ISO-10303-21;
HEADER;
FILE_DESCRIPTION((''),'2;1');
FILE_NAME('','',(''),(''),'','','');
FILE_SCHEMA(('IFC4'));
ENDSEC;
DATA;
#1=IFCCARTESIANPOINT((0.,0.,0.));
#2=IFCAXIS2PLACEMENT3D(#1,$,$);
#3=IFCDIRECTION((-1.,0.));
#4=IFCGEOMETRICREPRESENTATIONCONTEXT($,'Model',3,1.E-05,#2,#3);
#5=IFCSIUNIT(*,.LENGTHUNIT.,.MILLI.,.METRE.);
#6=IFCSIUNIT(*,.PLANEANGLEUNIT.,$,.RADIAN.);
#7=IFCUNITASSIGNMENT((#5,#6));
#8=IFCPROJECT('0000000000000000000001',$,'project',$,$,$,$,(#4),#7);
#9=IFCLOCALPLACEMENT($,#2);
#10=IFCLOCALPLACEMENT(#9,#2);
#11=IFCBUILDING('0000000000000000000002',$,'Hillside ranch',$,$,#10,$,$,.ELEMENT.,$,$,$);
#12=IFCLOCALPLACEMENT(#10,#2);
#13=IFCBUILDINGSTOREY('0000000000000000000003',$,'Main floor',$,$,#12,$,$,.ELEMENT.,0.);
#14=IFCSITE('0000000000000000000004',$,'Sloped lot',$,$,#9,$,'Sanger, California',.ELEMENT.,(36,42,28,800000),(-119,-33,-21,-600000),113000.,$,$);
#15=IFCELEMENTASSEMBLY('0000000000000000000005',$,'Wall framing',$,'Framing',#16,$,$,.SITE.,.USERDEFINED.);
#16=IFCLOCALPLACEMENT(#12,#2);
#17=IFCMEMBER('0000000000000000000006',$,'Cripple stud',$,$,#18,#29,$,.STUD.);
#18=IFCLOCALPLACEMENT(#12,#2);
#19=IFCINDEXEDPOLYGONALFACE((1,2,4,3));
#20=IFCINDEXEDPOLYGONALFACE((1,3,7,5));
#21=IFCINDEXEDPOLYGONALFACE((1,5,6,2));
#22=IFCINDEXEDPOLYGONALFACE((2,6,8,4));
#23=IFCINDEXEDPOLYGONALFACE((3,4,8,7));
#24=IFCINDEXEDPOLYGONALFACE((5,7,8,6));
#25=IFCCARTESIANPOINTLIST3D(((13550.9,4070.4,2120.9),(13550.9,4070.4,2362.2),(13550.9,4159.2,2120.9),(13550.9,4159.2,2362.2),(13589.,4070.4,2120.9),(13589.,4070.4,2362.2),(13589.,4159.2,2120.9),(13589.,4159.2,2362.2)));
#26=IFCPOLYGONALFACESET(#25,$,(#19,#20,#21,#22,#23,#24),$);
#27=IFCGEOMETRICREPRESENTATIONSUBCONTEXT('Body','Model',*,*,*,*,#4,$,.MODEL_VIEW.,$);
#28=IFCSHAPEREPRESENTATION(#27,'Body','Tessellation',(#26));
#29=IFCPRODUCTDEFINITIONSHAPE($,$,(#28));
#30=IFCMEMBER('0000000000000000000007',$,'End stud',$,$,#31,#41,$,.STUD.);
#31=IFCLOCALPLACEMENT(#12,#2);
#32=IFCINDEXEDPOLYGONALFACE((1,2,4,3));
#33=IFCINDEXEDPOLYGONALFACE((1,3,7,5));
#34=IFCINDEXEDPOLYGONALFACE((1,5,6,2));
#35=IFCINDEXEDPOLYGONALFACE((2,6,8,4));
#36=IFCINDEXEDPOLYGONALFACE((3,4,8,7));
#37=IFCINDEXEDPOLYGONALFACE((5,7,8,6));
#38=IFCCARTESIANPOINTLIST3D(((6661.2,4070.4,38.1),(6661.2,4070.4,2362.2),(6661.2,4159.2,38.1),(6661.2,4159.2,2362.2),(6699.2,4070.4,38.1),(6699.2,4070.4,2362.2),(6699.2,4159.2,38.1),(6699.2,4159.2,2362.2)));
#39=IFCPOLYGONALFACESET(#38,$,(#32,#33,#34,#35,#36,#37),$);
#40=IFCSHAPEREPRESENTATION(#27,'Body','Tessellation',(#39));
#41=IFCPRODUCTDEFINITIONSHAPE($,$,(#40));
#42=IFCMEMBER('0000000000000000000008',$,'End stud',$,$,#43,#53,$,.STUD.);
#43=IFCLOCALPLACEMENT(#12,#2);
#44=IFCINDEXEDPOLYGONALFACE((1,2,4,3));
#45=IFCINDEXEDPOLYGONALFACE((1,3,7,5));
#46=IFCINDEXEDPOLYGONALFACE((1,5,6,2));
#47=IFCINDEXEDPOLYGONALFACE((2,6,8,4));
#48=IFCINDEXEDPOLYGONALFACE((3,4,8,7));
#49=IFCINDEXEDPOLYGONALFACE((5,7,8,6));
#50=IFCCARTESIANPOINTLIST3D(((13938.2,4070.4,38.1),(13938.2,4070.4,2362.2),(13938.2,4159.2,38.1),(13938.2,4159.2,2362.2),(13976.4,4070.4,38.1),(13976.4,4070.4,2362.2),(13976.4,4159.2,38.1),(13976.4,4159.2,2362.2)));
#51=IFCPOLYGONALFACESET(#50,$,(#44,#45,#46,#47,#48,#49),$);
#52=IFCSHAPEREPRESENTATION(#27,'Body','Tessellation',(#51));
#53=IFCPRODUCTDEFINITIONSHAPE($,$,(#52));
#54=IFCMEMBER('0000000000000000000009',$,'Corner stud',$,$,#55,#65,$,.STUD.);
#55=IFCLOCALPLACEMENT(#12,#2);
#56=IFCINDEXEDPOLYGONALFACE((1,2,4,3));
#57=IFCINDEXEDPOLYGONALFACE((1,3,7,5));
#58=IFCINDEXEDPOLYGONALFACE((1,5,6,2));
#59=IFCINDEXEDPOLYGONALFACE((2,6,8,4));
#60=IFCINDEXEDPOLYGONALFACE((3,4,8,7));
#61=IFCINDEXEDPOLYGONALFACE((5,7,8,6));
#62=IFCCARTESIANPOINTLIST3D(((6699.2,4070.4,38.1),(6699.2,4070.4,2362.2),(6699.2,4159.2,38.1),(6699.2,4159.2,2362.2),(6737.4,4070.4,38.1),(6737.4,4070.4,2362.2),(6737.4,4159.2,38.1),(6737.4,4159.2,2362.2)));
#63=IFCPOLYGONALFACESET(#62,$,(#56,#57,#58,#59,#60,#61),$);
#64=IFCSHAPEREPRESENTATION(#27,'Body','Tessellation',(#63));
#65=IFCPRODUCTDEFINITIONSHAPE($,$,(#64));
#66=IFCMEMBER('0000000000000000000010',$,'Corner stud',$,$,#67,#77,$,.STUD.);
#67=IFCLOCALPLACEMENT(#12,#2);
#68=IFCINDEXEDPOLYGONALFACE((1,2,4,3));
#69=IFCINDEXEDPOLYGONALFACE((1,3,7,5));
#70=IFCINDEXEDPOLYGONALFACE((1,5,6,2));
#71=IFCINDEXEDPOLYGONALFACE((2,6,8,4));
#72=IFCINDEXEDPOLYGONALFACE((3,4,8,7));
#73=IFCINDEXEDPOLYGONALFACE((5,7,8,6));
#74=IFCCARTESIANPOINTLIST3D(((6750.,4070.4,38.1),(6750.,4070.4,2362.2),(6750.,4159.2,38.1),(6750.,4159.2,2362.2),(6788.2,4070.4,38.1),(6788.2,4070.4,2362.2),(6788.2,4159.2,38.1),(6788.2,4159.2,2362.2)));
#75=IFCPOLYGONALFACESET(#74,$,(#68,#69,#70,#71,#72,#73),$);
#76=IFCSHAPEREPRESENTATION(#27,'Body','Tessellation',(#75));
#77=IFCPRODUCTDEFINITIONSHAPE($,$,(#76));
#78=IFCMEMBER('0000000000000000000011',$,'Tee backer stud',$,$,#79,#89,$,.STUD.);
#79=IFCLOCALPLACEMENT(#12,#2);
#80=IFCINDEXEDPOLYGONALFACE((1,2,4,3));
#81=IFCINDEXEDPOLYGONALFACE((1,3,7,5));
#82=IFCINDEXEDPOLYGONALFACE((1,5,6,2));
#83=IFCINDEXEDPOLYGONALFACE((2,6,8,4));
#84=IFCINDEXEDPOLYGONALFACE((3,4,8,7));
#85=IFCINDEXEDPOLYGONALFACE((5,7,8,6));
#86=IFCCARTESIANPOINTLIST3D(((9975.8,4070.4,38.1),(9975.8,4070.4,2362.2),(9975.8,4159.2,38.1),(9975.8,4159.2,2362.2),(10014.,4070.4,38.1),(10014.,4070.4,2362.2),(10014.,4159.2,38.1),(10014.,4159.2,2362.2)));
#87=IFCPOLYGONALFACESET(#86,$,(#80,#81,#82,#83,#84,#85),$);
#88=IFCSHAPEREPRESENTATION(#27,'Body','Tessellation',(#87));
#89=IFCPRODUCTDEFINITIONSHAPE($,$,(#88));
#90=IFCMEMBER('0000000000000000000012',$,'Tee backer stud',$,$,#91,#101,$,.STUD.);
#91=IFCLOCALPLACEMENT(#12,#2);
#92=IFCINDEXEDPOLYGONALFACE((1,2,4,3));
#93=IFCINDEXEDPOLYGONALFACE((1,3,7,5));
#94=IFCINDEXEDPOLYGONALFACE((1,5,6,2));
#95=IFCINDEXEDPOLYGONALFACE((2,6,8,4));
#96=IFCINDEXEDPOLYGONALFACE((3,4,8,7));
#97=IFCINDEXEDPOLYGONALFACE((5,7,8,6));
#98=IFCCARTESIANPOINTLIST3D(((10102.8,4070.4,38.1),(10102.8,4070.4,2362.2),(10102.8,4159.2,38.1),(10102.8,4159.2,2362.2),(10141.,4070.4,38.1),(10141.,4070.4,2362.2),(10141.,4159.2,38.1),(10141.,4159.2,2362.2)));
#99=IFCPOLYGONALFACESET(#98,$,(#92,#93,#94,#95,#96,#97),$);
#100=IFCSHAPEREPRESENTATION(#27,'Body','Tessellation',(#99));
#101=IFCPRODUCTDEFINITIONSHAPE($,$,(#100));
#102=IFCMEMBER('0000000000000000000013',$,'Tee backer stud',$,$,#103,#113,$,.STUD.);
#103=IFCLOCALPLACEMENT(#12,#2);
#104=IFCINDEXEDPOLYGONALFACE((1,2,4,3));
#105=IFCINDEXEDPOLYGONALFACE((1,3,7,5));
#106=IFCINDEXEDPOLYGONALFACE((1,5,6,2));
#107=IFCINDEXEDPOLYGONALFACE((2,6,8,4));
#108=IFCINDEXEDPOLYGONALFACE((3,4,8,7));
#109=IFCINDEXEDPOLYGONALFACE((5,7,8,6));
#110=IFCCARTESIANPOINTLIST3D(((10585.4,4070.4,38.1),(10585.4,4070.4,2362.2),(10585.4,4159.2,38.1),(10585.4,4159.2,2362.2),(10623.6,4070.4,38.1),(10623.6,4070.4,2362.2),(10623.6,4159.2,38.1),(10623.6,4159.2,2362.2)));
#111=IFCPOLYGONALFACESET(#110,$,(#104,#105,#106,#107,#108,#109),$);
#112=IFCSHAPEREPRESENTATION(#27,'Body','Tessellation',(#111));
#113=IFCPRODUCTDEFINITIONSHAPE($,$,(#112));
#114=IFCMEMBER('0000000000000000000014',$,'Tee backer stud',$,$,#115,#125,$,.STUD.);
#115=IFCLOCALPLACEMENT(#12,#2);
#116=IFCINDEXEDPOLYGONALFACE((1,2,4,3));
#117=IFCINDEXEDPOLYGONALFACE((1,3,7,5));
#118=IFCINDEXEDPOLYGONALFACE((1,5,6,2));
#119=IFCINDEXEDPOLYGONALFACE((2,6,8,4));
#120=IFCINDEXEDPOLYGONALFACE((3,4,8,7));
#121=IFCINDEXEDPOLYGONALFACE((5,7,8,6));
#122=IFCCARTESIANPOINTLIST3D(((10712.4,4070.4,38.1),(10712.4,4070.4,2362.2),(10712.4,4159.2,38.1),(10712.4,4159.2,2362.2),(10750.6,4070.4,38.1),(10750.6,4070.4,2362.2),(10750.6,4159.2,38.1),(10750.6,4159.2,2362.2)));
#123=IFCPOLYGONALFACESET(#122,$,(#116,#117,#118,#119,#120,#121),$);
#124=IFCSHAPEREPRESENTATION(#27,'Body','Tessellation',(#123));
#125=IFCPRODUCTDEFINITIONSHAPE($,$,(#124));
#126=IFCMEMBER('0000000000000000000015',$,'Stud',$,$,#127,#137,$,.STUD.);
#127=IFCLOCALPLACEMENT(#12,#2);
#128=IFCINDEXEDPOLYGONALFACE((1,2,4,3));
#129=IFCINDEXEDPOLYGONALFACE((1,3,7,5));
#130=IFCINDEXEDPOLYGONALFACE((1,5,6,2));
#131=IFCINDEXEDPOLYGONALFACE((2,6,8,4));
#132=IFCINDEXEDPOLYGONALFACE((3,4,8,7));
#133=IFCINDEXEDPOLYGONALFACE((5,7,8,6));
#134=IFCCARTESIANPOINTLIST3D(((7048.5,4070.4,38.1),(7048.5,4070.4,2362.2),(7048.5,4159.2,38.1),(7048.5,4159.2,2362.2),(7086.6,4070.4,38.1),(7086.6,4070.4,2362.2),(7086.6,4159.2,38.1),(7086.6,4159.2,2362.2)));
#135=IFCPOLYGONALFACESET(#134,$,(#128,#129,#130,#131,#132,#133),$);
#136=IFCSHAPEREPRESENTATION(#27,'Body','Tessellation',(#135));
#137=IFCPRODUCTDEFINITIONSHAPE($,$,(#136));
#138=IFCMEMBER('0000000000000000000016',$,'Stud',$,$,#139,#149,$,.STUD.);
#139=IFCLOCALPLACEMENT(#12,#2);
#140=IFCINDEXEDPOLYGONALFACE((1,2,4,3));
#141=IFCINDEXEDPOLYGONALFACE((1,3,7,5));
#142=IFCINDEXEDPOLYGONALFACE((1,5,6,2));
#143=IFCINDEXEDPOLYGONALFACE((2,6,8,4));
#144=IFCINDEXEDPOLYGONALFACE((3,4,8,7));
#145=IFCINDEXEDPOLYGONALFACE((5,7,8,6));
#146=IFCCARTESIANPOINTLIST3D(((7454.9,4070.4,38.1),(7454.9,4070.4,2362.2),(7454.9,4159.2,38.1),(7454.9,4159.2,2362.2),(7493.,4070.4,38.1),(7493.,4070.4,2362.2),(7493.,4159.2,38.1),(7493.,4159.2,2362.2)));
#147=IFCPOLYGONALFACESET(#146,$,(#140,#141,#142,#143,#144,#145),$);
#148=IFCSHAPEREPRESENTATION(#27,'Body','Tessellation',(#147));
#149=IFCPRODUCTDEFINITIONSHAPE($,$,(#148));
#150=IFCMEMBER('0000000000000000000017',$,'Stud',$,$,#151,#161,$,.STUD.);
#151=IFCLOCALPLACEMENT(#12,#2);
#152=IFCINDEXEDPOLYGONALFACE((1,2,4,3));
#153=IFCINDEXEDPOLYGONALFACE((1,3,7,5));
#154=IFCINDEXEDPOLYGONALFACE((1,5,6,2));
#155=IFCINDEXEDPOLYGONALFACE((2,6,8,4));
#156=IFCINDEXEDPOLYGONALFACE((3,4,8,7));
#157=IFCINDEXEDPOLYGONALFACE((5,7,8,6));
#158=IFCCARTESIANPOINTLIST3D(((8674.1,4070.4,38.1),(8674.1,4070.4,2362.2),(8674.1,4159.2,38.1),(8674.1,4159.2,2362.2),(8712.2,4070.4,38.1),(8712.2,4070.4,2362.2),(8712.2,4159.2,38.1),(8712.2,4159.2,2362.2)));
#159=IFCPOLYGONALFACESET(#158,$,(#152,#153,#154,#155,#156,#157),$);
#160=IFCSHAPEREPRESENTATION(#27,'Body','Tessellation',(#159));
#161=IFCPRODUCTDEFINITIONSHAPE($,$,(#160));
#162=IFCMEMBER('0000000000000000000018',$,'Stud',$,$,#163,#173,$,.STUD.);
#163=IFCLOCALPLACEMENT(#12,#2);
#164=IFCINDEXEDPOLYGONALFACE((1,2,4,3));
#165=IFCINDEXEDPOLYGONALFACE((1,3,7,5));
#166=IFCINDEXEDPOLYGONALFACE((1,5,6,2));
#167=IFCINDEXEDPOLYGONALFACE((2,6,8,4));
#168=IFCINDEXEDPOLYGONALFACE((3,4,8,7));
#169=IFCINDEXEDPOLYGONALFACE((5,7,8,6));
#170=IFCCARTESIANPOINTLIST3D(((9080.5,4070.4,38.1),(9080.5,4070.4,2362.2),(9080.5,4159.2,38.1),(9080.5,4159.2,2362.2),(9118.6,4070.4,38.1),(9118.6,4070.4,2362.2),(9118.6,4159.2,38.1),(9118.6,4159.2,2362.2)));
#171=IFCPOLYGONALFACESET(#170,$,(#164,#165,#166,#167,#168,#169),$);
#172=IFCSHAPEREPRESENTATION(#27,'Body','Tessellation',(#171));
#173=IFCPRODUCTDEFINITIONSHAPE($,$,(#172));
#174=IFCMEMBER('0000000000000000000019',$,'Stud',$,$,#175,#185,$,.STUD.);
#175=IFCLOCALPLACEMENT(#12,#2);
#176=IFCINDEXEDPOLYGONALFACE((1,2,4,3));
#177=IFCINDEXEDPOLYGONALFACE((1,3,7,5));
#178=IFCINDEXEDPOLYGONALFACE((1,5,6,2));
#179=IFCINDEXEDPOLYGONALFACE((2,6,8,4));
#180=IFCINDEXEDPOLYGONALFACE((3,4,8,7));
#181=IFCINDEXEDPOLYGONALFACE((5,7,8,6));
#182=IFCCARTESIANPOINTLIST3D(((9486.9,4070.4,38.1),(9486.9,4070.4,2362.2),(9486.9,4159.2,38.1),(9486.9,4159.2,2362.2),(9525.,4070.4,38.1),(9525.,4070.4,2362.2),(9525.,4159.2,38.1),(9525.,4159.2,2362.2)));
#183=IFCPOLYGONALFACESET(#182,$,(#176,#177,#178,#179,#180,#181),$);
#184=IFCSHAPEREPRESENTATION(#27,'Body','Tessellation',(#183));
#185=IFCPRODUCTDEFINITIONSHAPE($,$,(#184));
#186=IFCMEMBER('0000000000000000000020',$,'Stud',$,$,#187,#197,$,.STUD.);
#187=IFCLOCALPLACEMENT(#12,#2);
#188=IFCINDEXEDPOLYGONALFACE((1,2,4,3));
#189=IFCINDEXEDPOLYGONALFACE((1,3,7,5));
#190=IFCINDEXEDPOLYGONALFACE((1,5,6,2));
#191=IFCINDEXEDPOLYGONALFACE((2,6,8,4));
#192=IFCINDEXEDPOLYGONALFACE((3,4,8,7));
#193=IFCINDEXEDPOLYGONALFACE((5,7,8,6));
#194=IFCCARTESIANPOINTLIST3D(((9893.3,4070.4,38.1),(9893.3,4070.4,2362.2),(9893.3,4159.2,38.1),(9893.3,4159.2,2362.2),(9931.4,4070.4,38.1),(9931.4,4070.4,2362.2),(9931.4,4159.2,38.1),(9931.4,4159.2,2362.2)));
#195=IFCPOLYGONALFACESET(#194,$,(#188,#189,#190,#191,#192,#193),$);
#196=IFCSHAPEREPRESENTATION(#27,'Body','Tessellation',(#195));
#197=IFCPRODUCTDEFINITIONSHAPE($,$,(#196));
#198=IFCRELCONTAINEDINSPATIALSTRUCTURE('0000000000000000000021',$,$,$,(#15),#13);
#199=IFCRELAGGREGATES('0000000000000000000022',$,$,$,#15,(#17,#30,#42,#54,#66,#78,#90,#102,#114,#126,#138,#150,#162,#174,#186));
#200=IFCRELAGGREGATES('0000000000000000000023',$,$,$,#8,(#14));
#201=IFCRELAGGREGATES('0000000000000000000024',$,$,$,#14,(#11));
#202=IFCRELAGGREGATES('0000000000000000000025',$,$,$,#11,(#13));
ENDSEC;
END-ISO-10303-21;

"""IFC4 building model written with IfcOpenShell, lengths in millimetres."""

from ifc_helpers import new_model, si_unit, direction, frame, origin, origin_with_axes, place, context, subcontext, project, spatial, polyline, outline, extrude, element, aggregate, save


model = new_model("IFC4")

# Units and contexts
model_context = context("Model", 3, precision=1e-05, world=origin(), true_north=direction((-1.0, 0.0)))
body_context = subcontext(model_context, "Body", "Model", "MODEL_VIEW")
ifc_project = project(units=[si_unit("LENGTHUNIT", "METRE", prefix="MILLI"), si_unit("PLANEANGLEUNIT", "RADIAN")], contexts=[model_context])

# Site, building, storey
site_placement = place(None, origin())
site = spatial("IfcSite", under=ifc_project, at=site_placement, Name="Sloped lot", LongName="Sanger, California", CompositionType="ELEMENT", RefLatitude=(36, 42, 28, 800000), RefLongitude=(-119, -33, -21, -600000), RefElevation=113000.0)
building_placement = place(site_placement, origin())
building = spatial("IfcBuilding", under=site, at=building_placement, Name="Hillside ranch", CompositionType="ELEMENT")
storey_placement = place(building_placement, origin())
storey = spatial("IfcBuildingStorey", under=building, at=storey_placement, Name="Main floor", CompositionType="ELEMENT", Elevation=0.0)

# Element assembly, members
assembly_placement = place(storey_placement, origin_with_axes())
assembly = element("IfcElementAssembly", 1, at=assembly_placement, inside=storey, Name="Wall framing", ObjectType="Framing", AssemblyPlace="SITE", PredefinedType="USERDEFINED")
member_1_placement = place(storey_placement, origin_with_axes())
member_1 = element("IfcMember", 2, at=member_1_placement, Name="Cripple stud", PredefinedType="STUD", context=body_context, shape_type="SweptSolid", body=[
    extrude(outline(polyline([(0.0, 0.0), (38.1, 0.0), (38.1, 88.9), (0.0, 88.9), (0.0, 0.0)])), frame((13550.9, 4070.3, 2120.9), z_axis=(0.0, 0.0, 1.0), x_axis=(1.0, 0.0, 0.0)), (0.0, 0.0, 1.0), 241.3),
])
member_2_placement = place(storey_placement, origin_with_axes())
member_2 = element("IfcMember", 3, at=member_2_placement, Name="End stud", PredefinedType="STUD", context=body_context, shape_type="SweptSolid", body=[
    extrude(outline(polyline([(0.0, 0.0), (38.1, 0.0), (38.1, 88.9), (0.0, 88.9), (0.0, 0.0)])), frame((6661.1, 4070.3, 38.1), z_axis=(0.0, 0.0, 1.0), x_axis=(1.0, 0.0, 0.0)), (0.0, 0.0, 1.0), 2324.1),
])
member_3_placement = place(storey_placement, origin_with_axes())
member_3 = element("IfcMember", 4, at=member_3_placement, Name="End stud", PredefinedType="STUD", context=body_context, shape_type="SweptSolid", body=[
    extrude(outline(polyline([(0.0, 0.0), (38.1, 0.0), (38.1, 88.9), (0.0, 88.9), (0.0, 0.0)])), frame((13938.2, 4070.3, 38.1), z_axis=(0.0, 0.0, 1.0), x_axis=(1.0, 0.0, 0.0)), (0.0, 0.0, 1.0), 2324.1),
])
member_4_placement = place(storey_placement, origin_with_axes())
member_4 = element("IfcMember", 5, at=member_4_placement, Name="Corner stud", PredefinedType="STUD", context=body_context, shape_type="SweptSolid", body=[
    extrude(outline(polyline([(0.0, 0.0), (38.1, 0.0), (38.1, 88.9), (0.0, 88.9), (0.0, 0.0)])), frame((6699.2, 4070.3, 38.1), z_axis=(0.0, 0.0, 1.0), x_axis=(1.0, 0.0, 0.0)), (0.0, 0.0, 1.0), 2324.1),
])
member_5_placement = place(storey_placement, origin_with_axes())
member_5 = element("IfcMember", 6, at=member_5_placement, Name="Corner stud", PredefinedType="STUD", context=body_context, shape_type="SweptSolid", body=[
    extrude(outline(polyline([(0.0, 0.0), (38.1, 0.0), (38.1, 88.9), (0.0, 88.9), (0.0, 0.0)])), frame((6750.1, 4070.3, 38.1), z_axis=(0.0, 0.0, 1.0), x_axis=(1.0, 0.0, 0.0)), (0.0, 0.0, 1.0), 2324.1),
])
member_6_placement = place(storey_placement, origin_with_axes())
member_6 = element("IfcMember", 7, at=member_6_placement, Name="Tee backer stud", PredefinedType="STUD", context=body_context, shape_type="SweptSolid", body=[
    extrude(outline(polyline([(0.0, 0.0), (38.1, 0.0), (38.1, 88.9), (0.0, 88.9), (0.0, 0.0)])), frame((9975.9, 4070.3, 38.1), z_axis=(0.0, 0.0, 1.0), x_axis=(1.0, 0.0, 0.0)), (0.0, 0.0, 1.0), 2324.1),
])
member_7_placement = place(storey_placement, origin_with_axes())
member_7 = element("IfcMember", 8, at=member_7_placement, Name="Tee backer stud", PredefinedType="STUD", context=body_context, shape_type="SweptSolid", body=[
    extrude(outline(polyline([(0.0, 0.0), (38.1, 0.0), (38.1, 88.9), (0.0, 88.9), (0.0, 0.0)])), frame((10102.9, 4070.3, 38.1), z_axis=(0.0, 0.0, 1.0), x_axis=(1.0, 0.0, 0.0)), (0.0, 0.0, 1.0), 2324.1),
])
member_8_placement = place(storey_placement, origin_with_axes())
member_8 = element("IfcMember", 9, at=member_8_placement, Name="Tee backer stud", PredefinedType="STUD", context=body_context, shape_type="SweptSolid", body=[
    extrude(outline(polyline([(0.0, 0.0), (38.1, 0.0), (38.1, 88.9), (0.0, 88.9), (0.0, 0.0)])), frame((10585.5, 4070.3, 38.1), z_axis=(0.0, 0.0, 1.0), x_axis=(1.0, 0.0, 0.0)), (0.0, 0.0, 1.0), 2324.1),
])
member_9_placement = place(storey_placement, origin_with_axes())
member_9 = element("IfcMember", 10, at=member_9_placement, Name="Tee backer stud", PredefinedType="STUD", context=body_context, shape_type="SweptSolid", body=[
    extrude(outline(polyline([(0.0, 0.0), (38.1, 0.0), (38.1, 88.9), (0.0, 88.9), (0.0, 0.0)])), frame((10712.5, 4070.3, 38.1), z_axis=(0.0, 0.0, 1.0), x_axis=(1.0, 0.0, 0.0)), (0.0, 0.0, 1.0), 2324.1),
])
member_10_placement = place(storey_placement, origin_with_axes())
member_10 = element("IfcMember", 11, at=member_10_placement, Name="Stud", PredefinedType="STUD", context=body_context, shape_type="SweptSolid", body=[
    extrude(outline(polyline([(0.0, 0.0), (38.1, 0.0), (38.1, 88.9), (0.0, 88.9), (0.0, 0.0)])), frame((7048.5, 4070.3, 38.1), z_axis=(0.0, 0.0, 1.0), x_axis=(1.0, 0.0, 0.0)), (0.0, 0.0, 1.0), 2324.1),
])
member_11_placement = place(storey_placement, origin_with_axes())
member_11 = element("IfcMember", 12, at=member_11_placement, Name="Stud", PredefinedType="STUD", context=body_context, shape_type="SweptSolid", body=[
    extrude(outline(polyline([(0.0, 0.0), (38.1, 0.0), (38.1, 88.9), (0.0, 88.9), (0.0, 0.0)])), frame((7454.9, 4070.3, 38.1), z_axis=(0.0, 0.0, 1.0), x_axis=(1.0, 0.0, 0.0)), (0.0, 0.0, 1.0), 2324.1),
])
member_12_placement = place(storey_placement, origin_with_axes())
member_12 = element("IfcMember", 13, at=member_12_placement, Name="Stud", PredefinedType="STUD", context=body_context, shape_type="SweptSolid", body=[
    extrude(outline(polyline([(0.0, 0.0), (38.1, 0.0), (38.1, 88.9), (0.0, 88.9), (0.0, 0.0)])), frame((8674.1, 4070.3, 38.1), z_axis=(0.0, 0.0, 1.0), x_axis=(1.0, 0.0, 0.0)), (0.0, 0.0, 1.0), 2324.1),
])
member_13_placement = place(storey_placement, origin_with_axes())
member_13 = element("IfcMember", 14, at=member_13_placement, Name="Stud", PredefinedType="STUD", context=body_context, shape_type="SweptSolid", body=[
    extrude(outline(polyline([(0.0, 0.0), (38.1, 0.0), (38.1, 88.9), (0.0, 88.9), (0.0, 0.0)])), frame((9080.5, 4070.3, 38.1), z_axis=(0.0, 0.0, 1.0), x_axis=(1.0, 0.0, 0.0)), (0.0, 0.0, 1.0), 2324.1),
])
member_14_placement = place(storey_placement, origin_with_axes())
member_14 = element("IfcMember", 15, at=member_14_placement, Name="Stud", PredefinedType="STUD", context=body_context, shape_type="SweptSolid", body=[
    extrude(outline(polyline([(0.0, 0.0), (38.1, 0.0), (38.1, 88.9), (0.0, 88.9), (0.0, 0.0)])), frame((9486.9, 4070.3, 38.1), z_axis=(0.0, 0.0, 1.0), x_axis=(1.0, 0.0, 0.0)), (0.0, 0.0, 1.0), 2324.1),
])
member_15_placement = place(storey_placement, origin_with_axes())
member_15 = element("IfcMember", 16, at=member_15_placement, Name="Stud", PredefinedType="STUD", context=body_context, shape_type="SweptSolid", body=[
    extrude(outline(polyline([(0.0, 0.0), (38.1, 0.0), (38.1, 88.9), (0.0, 88.9), (0.0, 0.0)])), frame((9893.3, 4070.3, 38.1), z_axis=(0.0, 0.0, 1.0), x_axis=(1.0, 0.0, 0.0)), (0.0, 0.0, 1.0), 2324.1),
])
aggregate(assembly, [member_1, member_2, member_3, member_4, member_5, member_6, member_7, member_8, member_9, member_10, member_11, member_12, member_13, member_14, member_15])

save(model, "model.ifc")
